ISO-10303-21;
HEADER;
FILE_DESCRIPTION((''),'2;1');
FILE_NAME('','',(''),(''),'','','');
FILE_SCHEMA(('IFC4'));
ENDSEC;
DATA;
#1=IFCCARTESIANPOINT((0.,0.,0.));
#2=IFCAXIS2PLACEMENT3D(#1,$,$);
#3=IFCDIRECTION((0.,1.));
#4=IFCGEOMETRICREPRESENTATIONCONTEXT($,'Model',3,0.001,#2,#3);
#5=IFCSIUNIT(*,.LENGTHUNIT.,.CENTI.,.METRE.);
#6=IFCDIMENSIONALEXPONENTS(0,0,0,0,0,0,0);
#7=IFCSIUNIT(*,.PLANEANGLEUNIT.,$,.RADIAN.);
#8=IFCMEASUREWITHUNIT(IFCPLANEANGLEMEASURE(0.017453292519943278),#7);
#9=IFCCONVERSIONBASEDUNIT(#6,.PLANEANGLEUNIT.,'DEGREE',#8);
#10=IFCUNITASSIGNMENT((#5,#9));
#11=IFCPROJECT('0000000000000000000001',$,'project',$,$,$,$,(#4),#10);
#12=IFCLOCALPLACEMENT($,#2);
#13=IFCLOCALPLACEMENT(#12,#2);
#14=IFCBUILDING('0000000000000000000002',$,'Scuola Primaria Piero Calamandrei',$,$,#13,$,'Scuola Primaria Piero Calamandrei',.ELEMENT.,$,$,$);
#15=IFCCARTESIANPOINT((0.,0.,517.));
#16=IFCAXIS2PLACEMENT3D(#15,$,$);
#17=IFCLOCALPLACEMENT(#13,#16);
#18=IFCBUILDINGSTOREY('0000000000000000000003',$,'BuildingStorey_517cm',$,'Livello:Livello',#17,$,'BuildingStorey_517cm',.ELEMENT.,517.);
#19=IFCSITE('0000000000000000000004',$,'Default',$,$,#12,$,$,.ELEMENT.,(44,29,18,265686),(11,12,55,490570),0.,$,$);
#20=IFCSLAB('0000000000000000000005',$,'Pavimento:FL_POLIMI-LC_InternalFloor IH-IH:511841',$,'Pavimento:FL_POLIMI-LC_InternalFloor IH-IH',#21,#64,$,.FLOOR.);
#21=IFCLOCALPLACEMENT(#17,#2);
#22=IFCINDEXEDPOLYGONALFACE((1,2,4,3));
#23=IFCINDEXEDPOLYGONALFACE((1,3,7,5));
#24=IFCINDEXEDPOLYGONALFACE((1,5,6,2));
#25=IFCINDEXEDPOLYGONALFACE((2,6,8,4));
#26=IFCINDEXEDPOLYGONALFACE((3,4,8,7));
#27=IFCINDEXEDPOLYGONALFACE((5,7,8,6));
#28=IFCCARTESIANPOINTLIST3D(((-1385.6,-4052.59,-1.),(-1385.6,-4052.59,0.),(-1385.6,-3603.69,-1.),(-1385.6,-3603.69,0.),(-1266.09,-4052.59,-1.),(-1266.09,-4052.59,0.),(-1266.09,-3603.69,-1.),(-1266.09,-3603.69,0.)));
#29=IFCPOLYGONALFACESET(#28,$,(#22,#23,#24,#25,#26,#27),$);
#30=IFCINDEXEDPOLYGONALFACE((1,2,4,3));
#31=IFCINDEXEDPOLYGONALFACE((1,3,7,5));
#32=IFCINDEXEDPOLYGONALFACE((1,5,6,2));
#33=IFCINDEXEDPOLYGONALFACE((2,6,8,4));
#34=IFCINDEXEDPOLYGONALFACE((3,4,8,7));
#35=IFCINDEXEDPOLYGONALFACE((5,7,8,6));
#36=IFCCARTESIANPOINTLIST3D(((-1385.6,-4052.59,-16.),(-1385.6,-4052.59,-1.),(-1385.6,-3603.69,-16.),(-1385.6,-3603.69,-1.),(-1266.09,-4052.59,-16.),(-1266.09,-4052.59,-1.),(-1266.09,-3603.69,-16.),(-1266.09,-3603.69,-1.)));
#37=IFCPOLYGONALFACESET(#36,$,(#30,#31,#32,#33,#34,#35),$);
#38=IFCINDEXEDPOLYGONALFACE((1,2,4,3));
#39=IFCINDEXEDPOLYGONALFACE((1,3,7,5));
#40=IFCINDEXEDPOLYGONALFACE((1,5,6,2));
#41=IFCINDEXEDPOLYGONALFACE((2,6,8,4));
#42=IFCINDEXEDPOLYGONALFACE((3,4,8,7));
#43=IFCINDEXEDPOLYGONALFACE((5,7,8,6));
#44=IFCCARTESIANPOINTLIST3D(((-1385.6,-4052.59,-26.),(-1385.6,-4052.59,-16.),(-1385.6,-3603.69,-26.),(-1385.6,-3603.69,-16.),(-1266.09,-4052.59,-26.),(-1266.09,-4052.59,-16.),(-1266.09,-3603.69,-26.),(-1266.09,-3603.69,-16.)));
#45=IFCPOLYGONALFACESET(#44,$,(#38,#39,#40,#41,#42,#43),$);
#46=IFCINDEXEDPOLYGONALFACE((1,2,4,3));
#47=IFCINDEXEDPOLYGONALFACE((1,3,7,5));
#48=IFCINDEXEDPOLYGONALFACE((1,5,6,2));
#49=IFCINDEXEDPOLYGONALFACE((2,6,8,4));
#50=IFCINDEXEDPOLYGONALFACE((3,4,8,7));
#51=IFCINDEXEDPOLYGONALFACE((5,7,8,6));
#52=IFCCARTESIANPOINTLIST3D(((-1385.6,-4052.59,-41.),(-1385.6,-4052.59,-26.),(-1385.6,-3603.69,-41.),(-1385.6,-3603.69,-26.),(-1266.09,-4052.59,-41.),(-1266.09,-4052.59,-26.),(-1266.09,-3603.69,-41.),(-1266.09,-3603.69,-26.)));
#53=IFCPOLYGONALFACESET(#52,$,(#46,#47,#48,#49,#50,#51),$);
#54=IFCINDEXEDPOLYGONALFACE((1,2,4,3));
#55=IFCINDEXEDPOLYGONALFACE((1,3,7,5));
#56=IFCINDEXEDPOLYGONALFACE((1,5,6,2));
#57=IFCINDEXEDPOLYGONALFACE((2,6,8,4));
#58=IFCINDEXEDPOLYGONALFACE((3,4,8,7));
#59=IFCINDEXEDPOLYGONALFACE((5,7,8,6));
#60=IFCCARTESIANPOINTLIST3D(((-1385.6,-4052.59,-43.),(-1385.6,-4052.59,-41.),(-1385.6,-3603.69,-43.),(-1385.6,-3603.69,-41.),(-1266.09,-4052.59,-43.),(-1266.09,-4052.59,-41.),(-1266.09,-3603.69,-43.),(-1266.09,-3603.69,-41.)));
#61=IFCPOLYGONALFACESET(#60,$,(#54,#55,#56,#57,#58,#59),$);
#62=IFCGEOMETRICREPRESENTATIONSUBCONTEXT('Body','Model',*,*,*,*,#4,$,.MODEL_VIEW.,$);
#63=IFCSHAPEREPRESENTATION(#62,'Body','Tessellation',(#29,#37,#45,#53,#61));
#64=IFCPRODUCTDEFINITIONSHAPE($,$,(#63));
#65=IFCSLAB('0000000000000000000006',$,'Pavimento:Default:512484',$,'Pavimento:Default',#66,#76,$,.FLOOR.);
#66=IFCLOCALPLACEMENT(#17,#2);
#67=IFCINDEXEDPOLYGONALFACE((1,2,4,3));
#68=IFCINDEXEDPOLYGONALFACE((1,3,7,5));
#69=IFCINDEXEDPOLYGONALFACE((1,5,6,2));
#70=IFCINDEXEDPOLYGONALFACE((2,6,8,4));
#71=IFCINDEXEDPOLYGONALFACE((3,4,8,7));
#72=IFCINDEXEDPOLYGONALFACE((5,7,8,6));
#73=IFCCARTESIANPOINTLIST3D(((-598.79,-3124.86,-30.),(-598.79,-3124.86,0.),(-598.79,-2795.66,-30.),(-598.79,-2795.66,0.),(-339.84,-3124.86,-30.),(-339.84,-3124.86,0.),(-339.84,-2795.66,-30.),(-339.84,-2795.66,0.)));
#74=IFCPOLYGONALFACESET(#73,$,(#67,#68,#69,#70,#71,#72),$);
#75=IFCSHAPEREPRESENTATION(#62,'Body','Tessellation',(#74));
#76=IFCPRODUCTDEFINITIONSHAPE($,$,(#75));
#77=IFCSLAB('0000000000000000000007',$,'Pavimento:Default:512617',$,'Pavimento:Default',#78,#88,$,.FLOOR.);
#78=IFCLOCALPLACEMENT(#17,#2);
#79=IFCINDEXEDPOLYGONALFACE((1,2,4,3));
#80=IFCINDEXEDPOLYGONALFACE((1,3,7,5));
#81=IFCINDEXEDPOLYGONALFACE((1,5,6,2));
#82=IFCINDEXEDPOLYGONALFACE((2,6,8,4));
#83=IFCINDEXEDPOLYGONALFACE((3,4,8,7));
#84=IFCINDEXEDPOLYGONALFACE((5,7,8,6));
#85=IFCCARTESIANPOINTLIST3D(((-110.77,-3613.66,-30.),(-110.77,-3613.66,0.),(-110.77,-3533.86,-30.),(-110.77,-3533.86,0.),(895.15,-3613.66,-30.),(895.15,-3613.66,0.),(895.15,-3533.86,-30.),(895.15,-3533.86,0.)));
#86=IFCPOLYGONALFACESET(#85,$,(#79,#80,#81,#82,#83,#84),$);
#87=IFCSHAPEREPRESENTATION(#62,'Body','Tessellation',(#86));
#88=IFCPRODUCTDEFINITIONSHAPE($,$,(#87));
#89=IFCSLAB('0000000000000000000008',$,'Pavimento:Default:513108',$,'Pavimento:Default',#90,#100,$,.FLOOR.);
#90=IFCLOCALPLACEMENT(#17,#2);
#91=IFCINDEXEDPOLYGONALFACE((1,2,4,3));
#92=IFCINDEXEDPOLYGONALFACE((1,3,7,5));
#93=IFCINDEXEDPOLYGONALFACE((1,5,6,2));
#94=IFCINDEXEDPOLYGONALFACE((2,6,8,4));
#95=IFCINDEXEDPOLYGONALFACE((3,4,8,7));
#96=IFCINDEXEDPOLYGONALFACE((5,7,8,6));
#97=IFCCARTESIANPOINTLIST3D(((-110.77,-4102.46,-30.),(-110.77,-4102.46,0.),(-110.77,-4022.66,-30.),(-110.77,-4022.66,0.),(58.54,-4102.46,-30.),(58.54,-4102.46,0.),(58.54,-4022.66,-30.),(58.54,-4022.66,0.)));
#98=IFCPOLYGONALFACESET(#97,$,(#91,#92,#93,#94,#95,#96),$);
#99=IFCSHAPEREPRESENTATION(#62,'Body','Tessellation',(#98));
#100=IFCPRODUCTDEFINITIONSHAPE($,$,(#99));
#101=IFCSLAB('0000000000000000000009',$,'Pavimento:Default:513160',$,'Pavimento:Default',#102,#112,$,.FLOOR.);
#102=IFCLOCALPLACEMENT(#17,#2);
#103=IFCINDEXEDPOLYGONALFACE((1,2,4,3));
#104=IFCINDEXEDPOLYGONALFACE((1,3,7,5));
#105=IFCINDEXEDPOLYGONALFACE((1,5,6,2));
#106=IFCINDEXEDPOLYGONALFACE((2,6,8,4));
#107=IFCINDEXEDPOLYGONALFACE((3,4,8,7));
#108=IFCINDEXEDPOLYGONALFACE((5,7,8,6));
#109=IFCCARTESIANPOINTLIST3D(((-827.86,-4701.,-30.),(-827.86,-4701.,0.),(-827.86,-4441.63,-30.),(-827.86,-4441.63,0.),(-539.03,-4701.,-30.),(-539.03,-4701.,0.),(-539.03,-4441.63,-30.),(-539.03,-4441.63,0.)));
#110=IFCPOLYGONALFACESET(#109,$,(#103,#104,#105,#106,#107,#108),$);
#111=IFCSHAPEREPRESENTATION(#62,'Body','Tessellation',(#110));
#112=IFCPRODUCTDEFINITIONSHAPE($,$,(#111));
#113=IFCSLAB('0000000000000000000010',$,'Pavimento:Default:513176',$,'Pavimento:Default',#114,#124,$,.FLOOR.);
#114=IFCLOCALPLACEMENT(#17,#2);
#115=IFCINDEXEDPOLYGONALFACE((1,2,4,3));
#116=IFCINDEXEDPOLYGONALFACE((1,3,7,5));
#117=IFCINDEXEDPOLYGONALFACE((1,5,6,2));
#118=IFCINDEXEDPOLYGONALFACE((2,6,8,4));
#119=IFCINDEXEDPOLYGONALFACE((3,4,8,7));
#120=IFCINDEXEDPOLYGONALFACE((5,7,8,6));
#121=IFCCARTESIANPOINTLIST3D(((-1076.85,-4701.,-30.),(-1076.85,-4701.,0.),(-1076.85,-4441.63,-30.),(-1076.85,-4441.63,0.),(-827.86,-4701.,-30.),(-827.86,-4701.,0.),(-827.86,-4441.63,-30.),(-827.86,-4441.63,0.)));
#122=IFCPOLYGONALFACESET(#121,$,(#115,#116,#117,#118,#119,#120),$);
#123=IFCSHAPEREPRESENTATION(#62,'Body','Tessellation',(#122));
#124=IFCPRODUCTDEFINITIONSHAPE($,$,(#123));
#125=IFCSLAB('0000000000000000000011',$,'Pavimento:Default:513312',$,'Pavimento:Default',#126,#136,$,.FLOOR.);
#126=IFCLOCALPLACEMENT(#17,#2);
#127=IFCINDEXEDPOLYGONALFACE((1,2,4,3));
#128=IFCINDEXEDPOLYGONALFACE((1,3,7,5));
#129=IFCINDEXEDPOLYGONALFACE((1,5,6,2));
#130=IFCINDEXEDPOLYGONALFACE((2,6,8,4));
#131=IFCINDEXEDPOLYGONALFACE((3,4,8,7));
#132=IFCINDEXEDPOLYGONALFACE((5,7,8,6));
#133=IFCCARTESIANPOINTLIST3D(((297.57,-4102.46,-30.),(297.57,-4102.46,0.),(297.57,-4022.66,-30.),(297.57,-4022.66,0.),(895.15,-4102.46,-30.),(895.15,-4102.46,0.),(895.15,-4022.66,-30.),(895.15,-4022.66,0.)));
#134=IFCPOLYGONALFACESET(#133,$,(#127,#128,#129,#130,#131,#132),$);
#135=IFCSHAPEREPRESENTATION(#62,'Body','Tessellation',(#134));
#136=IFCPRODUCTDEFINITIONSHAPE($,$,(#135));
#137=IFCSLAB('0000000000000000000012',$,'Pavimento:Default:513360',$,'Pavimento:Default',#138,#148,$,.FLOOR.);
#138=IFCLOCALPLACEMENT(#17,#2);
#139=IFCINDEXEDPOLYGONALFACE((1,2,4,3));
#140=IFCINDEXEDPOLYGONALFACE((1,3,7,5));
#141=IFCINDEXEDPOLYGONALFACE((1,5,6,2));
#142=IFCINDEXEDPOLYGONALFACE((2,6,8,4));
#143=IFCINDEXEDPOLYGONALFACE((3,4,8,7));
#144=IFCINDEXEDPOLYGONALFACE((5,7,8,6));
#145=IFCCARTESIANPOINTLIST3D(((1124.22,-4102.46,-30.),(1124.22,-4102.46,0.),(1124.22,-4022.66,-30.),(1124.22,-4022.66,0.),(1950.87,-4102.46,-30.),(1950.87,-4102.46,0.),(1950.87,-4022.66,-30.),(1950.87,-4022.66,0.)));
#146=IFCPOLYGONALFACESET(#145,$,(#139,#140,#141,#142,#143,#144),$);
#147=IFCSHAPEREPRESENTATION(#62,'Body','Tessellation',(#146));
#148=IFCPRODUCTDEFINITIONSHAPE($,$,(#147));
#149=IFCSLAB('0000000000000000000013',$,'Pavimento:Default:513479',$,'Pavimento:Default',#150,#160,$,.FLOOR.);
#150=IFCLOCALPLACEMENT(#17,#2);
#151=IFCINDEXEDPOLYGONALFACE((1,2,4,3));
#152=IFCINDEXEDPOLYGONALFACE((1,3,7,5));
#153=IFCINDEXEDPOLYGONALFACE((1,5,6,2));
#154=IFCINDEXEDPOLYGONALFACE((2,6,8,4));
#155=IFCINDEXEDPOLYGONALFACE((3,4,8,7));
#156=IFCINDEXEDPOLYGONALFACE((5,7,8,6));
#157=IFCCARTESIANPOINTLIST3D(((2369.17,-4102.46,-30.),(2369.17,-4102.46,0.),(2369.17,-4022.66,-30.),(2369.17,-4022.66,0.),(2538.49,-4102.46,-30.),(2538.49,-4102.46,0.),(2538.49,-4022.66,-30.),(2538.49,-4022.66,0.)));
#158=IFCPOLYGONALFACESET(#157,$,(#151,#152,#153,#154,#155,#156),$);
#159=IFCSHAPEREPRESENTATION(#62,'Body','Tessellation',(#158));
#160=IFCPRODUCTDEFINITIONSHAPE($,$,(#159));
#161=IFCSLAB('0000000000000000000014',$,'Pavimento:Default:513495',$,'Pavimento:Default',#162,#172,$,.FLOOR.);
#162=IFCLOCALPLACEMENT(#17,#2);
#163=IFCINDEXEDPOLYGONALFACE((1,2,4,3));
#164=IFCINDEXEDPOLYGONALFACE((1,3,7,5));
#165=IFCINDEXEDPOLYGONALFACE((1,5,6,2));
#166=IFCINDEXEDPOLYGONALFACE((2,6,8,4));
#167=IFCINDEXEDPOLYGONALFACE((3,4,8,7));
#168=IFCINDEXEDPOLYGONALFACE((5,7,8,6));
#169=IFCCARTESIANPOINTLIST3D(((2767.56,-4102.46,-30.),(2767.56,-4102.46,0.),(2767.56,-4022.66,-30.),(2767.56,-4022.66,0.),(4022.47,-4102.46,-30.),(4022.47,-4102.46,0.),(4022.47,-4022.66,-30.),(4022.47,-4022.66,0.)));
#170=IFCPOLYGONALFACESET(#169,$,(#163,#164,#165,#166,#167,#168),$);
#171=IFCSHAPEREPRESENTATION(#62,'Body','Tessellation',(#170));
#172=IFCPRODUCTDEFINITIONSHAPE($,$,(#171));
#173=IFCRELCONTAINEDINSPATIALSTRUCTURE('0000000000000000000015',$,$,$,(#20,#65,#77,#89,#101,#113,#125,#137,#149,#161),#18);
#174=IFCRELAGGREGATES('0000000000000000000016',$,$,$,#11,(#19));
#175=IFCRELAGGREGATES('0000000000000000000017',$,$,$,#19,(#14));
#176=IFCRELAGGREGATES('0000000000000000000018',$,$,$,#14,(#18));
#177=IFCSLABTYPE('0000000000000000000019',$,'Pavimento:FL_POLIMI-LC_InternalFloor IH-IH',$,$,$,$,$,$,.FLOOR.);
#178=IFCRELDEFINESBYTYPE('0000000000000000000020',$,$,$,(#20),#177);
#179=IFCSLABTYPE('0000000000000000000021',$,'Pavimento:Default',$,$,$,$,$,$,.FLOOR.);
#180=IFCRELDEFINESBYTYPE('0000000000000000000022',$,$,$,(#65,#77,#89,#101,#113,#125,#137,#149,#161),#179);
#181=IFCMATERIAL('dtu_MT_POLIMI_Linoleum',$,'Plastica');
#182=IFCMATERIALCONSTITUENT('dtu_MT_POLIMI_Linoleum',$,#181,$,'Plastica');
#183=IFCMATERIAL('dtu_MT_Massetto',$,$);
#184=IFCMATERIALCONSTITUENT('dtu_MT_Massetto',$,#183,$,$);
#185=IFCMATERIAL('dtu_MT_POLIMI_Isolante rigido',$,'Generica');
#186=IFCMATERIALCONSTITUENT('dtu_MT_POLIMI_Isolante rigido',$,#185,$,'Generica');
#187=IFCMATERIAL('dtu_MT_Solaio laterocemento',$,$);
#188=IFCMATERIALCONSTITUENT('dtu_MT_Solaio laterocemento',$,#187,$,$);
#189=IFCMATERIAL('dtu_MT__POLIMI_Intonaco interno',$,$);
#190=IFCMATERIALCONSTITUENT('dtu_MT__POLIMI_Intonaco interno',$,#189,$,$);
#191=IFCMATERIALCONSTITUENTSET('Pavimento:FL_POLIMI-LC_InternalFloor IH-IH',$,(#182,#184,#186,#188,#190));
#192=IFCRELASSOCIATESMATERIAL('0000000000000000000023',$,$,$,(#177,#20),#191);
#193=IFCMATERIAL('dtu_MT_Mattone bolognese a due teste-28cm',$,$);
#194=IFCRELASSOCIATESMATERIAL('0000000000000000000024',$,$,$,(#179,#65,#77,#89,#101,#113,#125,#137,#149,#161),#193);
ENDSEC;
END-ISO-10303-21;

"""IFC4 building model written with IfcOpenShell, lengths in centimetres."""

from ifc_helpers import new_model, entity, si_unit, converted_unit, direction, frame, origin, place, context, subcontext, project, spatial, indexed_curve, outline, extrude, material, constituent, constituent_set, type_object, element, save


model = new_model("IFC4")

# Units and contexts
model_context = context("Model", 3, precision=0.001, world=origin(), true_north=direction((0.0, 1.0)))
body_context = subcontext(model_context, "Body", "Model", "MODEL_VIEW")
ifc_project = project(units=[si_unit("LENGTHUNIT", "METRE", prefix="CENTI"), converted_unit("PLANEANGLEUNIT", "DEGREE", entity("IfcPlaneAngleMeasure", 0.017453292519943278), si_unit("PLANEANGLEUNIT", "RADIAN"), dimensions=[0, 0, 0, 0, 0, 0, 0])], contexts=[model_context])

# Site, building, storey
site_placement = place(None, origin())
site = spatial("IfcSite", under=ifc_project, at=site_placement, Name="Default", CompositionType="ELEMENT", RefLatitude=(44, 29, 18, 265686), RefLongitude=(11, 12, 55, 490570), RefElevation=0.0)
building_placement = place(site_placement, origin())
building = spatial("IfcBuilding", under=site, at=building_placement, Name="Scuola Primaria Piero Calamandrei", LongName="Scuola Primaria Piero Calamandrei", CompositionType="ELEMENT")
storey_placement = place(building_placement, frame((0.0, 0.0, 517.0)))
storey = spatial("IfcBuildingStorey", under=building, at=storey_placement, Name="BuildingStorey_517cm", ObjectType="Livello:Livello", LongName="BuildingStorey_517cm", CompositionType="ELEMENT", Elevation=517.0)

# Slabs
ifc_material_1 = material(Name="dtu_MT_POLIMI_Linoleum", Category="Plastica")
ifc_constituent_1 = constituent(ifc_material_1, Name="dtu_MT_POLIMI_Linoleum", Category="Plastica")
ifc_material_2 = material(Name="dtu_MT_Massetto")
ifc_constituent_2 = constituent(ifc_material_2, Name="dtu_MT_Massetto")
ifc_material_3 = material(Name="dtu_MT_POLIMI_Isolante rigido", Category="Generica")
ifc_constituent_3 = constituent(ifc_material_3, Name="dtu_MT_POLIMI_Isolante rigido", Category="Generica")
ifc_material_4 = material(Name="dtu_MT_Solaio laterocemento")
ifc_constituent_4 = constituent(ifc_material_4, Name="dtu_MT_Solaio laterocemento")
ifc_material_5 = material(Name="dtu_MT__POLIMI_Intonaco interno")
ifc_constituent_5 = constituent(ifc_material_5, Name="dtu_MT__POLIMI_Intonaco interno")
ifc_constituent_set_1 = constituent_set(constituents=[ifc_constituent_1, ifc_constituent_2, ifc_constituent_3, ifc_constituent_4, ifc_constituent_5], Name="Pavimento:FL_POLIMI-LC_InternalFloor IH-IH")
slab_type_1 = type_object("IfcSlabType", Name="Pavimento:FL_POLIMI-LC_InternalFloor IH-IH", PredefinedType="FLOOR", material=ifc_constituent_set_1)
slab_1_placement = place(storey_placement, origin())
element("IfcSlab", 1, at=slab_1_placement, inside=storey, type_object=slab_type_1, material=ifc_constituent_set_1, Name="Pavimento:FL_POLIMI-LC_InternalFloor IH-IH:511841", ObjectType="Pavimento:FL_POLIMI-LC_InternalFloor IH-IH", PredefinedType="FLOOR", context=body_context, shape_type="SweptSolid", body=[
    extrude(outline(indexed_curve([(-224.45, -59.76), (224.45, -59.76), (224.45, 59.76), (-224.45, 59.76), (-224.45, -59.76)], self_intersect=False)), frame((-1325.84, -3828.14, -1.0), z_axis=(0.0, 0.0, 1.0), x_axis=(0.0, -1.0, 0.0)), (0.0, 0.0, 1.0), 1.0),
    extrude(outline(indexed_curve([(-224.45, -59.76), (224.45, -59.76), (224.45, 59.76), (-224.45, 59.76), (-224.45, -59.76)], self_intersect=False)), frame((-1325.84, -3828.14, -16.0), z_axis=(0.0, 0.0, 1.0), x_axis=(0.0, -1.0, 0.0)), (0.0, 0.0, 1.0), 15.0),
    extrude(outline(indexed_curve([(-224.45, -59.76), (224.45, -59.76), (224.45, 59.76), (-224.45, 59.76), (-224.45, -59.76)], self_intersect=False)), frame((-1325.84, -3828.14, -26.0), z_axis=(0.0, 0.0, 1.0), x_axis=(0.0, -1.0, 0.0)), (0.0, 0.0, 1.0), 10.0),
    extrude(outline(indexed_curve([(-224.45, -59.76), (224.45, -59.76), (224.45, 59.76), (-224.45, 59.76), (-224.45, -59.76)], self_intersect=False)), frame((-1325.84, -3828.14, -41.0), z_axis=(0.0, 0.0, 1.0), x_axis=(0.0, -1.0, 0.0)), (0.0, 0.0, 1.0), 15.0),
    extrude(outline(indexed_curve([(-224.45, -59.76), (224.45, -59.76), (224.45, 59.76), (-224.45, 59.76), (-224.45, -59.76)], self_intersect=False)), frame((-1325.84, -3828.14, -43.0), z_axis=(0.0, 0.0, 1.0), x_axis=(0.0, -1.0, 0.0)), (0.0, 0.0, 1.0), 2.0),
])
ifc_material_6 = material(Name="dtu_MT_Mattone bolognese a due teste-28cm")
slab_type_2 = type_object("IfcSlabType", Name="Pavimento:Default", PredefinedType="FLOOR", material=ifc_material_6)
slab_2_placement = place(storey_placement, origin())
element("IfcSlab", 2, at=slab_2_placement, inside=storey, type_object=slab_type_2, material=ifc_material_6, Name="Pavimento:Default:512484", ObjectType="Pavimento:Default", PredefinedType="FLOOR", context=body_context, shape_type="SweptSolid", body=[
    extrude(outline(indexed_curve([(-164.6, -129.47), (164.6, -129.47), (164.6, 129.47), (-164.6, 129.47), (-164.6, -129.47)], self_intersect=False)), frame((-469.32, -2960.26, 0.0), z_axis=(0.0, 0.0, -1.0), x_axis=(0.0, 1.0, 0.0)), (0.0, 0.0, 1.0), 30.0),
])
slab_3_placement = place(storey_placement, origin())
element("IfcSlab", 3, at=slab_3_placement, inside=storey, type_object=slab_type_2, material=ifc_material_6, Name="Pavimento:Default:512617", ObjectType="Pavimento:Default", PredefinedType="FLOOR", context=body_context, shape_type="SweptSolid", body=[
    extrude(outline(indexed_curve([(-39.9, -502.96), (39.9, -502.96), (39.9, 502.96), (-39.9, 502.96), (-39.9, -502.96)], self_intersect=False)), frame((392.19, -3573.76, 0.0), z_axis=(0.0, 0.0, -1.0), x_axis=(0.0, 1.0, 0.0)), (0.0, 0.0, 1.0), 30.0),
])
slab_4_placement = place(storey_placement, origin())
element("IfcSlab", 4, at=slab_4_placement, inside=storey, type_object=slab_type_2, material=ifc_material_6, Name="Pavimento:Default:513108", ObjectType="Pavimento:Default", PredefinedType="FLOOR", context=body_context, shape_type="SweptSolid", body=[
    extrude(outline(indexed_curve([(-39.9, -84.66), (39.9, -84.66), (39.9, 84.66), (-39.9, 84.66), (-39.9, -84.66)], self_intersect=False)), frame((-26.11, -4062.56, 0.0), z_axis=(0.0, 0.0, -1.0), x_axis=(0.0, 1.0, 0.0)), (0.0, 0.0, 1.0), 30.0),
])
slab_5_placement = place(storey_placement, origin())
element("IfcSlab", 5, at=slab_5_placement, inside=storey, type_object=slab_type_2, material=ifc_material_6, Name="Pavimento:Default:513160", ObjectType="Pavimento:Default", PredefinedType="FLOOR", context=body_context, shape_type="SweptSolid", body=[
    extrude(outline(indexed_curve([(-129.68, -144.41), (129.68, -144.41), (129.68, 144.41), (-129.68, 144.41), (-129.68, -144.41)], self_intersect=False)), frame((-683.45, -4571.31, 0.0), z_axis=(0.0, 0.0, -1.0), x_axis=(0.0, 1.0, 0.0)), (0.0, 0.0, 1.0), 30.0),
])
slab_6_placement = place(storey_placement, origin())
element("IfcSlab", 6, at=slab_6_placement, inside=storey, type_object=slab_type_2, material=ifc_material_6, Name="Pavimento:Default:513176", ObjectType="Pavimento:Default", PredefinedType="FLOOR", context=body_context, shape_type="SweptSolid", body=[
    extrude(outline(indexed_curve([(-129.68, -124.5), (129.68, -124.5), (129.68, 124.5), (-129.68, 124.5), (-129.68, -124.5)], self_intersect=False)), frame((-952.36, -4571.31, 0.0), z_axis=(0.0, 0.0, -1.0), x_axis=(0.0, 1.0, 0.0)), (0.0, 0.0, 1.0), 30.0),
])
slab_7_placement = place(storey_placement, origin())
element("IfcSlab", 7, at=slab_7_placement, inside=storey, type_object=slab_type_2, material=ifc_material_6, Name="Pavimento:Default:513312", ObjectType="Pavimento:Default", PredefinedType="FLOOR", context=body_context, shape_type="SweptSolid", body=[
    extrude(outline(indexed_curve([(-39.9, -298.79), (39.9, -298.79), (39.9, 298.79), (-39.9, 298.79), (-39.9, -298.79)], self_intersect=False)), frame((596.36, -4062.56, 0.0), z_axis=(0.0, 0.0, -1.0), x_axis=(0.0, 1.0, 0.0)), (0.0, 0.0, 1.0), 30.0),
])
slab_8_placement = place(storey_placement, origin())
element("IfcSlab", 8, at=slab_8_placement, inside=storey, type_object=slab_type_2, material=ifc_material_6, Name="Pavimento:Default:513360", ObjectType="Pavimento:Default", PredefinedType="FLOOR", context=body_context, shape_type="SweptSolid", body=[
    extrude(outline(indexed_curve([(-39.9, -413.32), (39.9, -413.32), (39.9, 413.32), (-39.9, 413.32), (-39.9, -413.32)], self_intersect=False)), frame((1537.55, -4062.56, 0.0), z_axis=(0.0, 0.0, -1.0), x_axis=(0.0, 1.0, 0.0)), (0.0, 0.0, 1.0), 30.0),
])
slab_9_placement = place(storey_placement, origin())
element("IfcSlab", 9, at=slab_9_placement, inside=storey, type_object=slab_type_2, material=ifc_material_6, Name="Pavimento:Default:513479", ObjectType="Pavimento:Default", PredefinedType="FLOOR", context=body_context, shape_type="SweptSolid", body=[
    extrude(outline(indexed_curve([(-39.9, -84.66), (39.9, -84.66), (39.9, 84.66), (-39.9, 84.66), (-39.9, -84.66)], self_intersect=False)), frame((2453.83, -4062.56, 0.0), z_axis=(0.0, 0.0, -1.0), x_axis=(0.0, 1.0, 0.0)), (0.0, 0.0, 1.0), 30.0),
])
slab_10_placement = place(storey_placement, origin())
element("IfcSlab", 10, at=slab_10_placement, inside=storey, type_object=slab_type_2, material=ifc_material_6, Name="Pavimento:Default:513495", ObjectType="Pavimento:Default", PredefinedType="FLOOR", context=body_context, shape_type="SweptSolid", body=[
    extrude(outline(indexed_curve([(-39.9, -627.46), (39.9, -627.46), (39.9, 627.46), (-39.9, 627.46), (-39.9, -627.46)], self_intersect=False)), frame((3395.02, -4062.56, 0.0), z_axis=(0.0, 0.0, -1.0), x_axis=(0.0, 1.0, 0.0)), (0.0, 0.0, 1.0), 30.0),
])

save(model, "model.ifc")
